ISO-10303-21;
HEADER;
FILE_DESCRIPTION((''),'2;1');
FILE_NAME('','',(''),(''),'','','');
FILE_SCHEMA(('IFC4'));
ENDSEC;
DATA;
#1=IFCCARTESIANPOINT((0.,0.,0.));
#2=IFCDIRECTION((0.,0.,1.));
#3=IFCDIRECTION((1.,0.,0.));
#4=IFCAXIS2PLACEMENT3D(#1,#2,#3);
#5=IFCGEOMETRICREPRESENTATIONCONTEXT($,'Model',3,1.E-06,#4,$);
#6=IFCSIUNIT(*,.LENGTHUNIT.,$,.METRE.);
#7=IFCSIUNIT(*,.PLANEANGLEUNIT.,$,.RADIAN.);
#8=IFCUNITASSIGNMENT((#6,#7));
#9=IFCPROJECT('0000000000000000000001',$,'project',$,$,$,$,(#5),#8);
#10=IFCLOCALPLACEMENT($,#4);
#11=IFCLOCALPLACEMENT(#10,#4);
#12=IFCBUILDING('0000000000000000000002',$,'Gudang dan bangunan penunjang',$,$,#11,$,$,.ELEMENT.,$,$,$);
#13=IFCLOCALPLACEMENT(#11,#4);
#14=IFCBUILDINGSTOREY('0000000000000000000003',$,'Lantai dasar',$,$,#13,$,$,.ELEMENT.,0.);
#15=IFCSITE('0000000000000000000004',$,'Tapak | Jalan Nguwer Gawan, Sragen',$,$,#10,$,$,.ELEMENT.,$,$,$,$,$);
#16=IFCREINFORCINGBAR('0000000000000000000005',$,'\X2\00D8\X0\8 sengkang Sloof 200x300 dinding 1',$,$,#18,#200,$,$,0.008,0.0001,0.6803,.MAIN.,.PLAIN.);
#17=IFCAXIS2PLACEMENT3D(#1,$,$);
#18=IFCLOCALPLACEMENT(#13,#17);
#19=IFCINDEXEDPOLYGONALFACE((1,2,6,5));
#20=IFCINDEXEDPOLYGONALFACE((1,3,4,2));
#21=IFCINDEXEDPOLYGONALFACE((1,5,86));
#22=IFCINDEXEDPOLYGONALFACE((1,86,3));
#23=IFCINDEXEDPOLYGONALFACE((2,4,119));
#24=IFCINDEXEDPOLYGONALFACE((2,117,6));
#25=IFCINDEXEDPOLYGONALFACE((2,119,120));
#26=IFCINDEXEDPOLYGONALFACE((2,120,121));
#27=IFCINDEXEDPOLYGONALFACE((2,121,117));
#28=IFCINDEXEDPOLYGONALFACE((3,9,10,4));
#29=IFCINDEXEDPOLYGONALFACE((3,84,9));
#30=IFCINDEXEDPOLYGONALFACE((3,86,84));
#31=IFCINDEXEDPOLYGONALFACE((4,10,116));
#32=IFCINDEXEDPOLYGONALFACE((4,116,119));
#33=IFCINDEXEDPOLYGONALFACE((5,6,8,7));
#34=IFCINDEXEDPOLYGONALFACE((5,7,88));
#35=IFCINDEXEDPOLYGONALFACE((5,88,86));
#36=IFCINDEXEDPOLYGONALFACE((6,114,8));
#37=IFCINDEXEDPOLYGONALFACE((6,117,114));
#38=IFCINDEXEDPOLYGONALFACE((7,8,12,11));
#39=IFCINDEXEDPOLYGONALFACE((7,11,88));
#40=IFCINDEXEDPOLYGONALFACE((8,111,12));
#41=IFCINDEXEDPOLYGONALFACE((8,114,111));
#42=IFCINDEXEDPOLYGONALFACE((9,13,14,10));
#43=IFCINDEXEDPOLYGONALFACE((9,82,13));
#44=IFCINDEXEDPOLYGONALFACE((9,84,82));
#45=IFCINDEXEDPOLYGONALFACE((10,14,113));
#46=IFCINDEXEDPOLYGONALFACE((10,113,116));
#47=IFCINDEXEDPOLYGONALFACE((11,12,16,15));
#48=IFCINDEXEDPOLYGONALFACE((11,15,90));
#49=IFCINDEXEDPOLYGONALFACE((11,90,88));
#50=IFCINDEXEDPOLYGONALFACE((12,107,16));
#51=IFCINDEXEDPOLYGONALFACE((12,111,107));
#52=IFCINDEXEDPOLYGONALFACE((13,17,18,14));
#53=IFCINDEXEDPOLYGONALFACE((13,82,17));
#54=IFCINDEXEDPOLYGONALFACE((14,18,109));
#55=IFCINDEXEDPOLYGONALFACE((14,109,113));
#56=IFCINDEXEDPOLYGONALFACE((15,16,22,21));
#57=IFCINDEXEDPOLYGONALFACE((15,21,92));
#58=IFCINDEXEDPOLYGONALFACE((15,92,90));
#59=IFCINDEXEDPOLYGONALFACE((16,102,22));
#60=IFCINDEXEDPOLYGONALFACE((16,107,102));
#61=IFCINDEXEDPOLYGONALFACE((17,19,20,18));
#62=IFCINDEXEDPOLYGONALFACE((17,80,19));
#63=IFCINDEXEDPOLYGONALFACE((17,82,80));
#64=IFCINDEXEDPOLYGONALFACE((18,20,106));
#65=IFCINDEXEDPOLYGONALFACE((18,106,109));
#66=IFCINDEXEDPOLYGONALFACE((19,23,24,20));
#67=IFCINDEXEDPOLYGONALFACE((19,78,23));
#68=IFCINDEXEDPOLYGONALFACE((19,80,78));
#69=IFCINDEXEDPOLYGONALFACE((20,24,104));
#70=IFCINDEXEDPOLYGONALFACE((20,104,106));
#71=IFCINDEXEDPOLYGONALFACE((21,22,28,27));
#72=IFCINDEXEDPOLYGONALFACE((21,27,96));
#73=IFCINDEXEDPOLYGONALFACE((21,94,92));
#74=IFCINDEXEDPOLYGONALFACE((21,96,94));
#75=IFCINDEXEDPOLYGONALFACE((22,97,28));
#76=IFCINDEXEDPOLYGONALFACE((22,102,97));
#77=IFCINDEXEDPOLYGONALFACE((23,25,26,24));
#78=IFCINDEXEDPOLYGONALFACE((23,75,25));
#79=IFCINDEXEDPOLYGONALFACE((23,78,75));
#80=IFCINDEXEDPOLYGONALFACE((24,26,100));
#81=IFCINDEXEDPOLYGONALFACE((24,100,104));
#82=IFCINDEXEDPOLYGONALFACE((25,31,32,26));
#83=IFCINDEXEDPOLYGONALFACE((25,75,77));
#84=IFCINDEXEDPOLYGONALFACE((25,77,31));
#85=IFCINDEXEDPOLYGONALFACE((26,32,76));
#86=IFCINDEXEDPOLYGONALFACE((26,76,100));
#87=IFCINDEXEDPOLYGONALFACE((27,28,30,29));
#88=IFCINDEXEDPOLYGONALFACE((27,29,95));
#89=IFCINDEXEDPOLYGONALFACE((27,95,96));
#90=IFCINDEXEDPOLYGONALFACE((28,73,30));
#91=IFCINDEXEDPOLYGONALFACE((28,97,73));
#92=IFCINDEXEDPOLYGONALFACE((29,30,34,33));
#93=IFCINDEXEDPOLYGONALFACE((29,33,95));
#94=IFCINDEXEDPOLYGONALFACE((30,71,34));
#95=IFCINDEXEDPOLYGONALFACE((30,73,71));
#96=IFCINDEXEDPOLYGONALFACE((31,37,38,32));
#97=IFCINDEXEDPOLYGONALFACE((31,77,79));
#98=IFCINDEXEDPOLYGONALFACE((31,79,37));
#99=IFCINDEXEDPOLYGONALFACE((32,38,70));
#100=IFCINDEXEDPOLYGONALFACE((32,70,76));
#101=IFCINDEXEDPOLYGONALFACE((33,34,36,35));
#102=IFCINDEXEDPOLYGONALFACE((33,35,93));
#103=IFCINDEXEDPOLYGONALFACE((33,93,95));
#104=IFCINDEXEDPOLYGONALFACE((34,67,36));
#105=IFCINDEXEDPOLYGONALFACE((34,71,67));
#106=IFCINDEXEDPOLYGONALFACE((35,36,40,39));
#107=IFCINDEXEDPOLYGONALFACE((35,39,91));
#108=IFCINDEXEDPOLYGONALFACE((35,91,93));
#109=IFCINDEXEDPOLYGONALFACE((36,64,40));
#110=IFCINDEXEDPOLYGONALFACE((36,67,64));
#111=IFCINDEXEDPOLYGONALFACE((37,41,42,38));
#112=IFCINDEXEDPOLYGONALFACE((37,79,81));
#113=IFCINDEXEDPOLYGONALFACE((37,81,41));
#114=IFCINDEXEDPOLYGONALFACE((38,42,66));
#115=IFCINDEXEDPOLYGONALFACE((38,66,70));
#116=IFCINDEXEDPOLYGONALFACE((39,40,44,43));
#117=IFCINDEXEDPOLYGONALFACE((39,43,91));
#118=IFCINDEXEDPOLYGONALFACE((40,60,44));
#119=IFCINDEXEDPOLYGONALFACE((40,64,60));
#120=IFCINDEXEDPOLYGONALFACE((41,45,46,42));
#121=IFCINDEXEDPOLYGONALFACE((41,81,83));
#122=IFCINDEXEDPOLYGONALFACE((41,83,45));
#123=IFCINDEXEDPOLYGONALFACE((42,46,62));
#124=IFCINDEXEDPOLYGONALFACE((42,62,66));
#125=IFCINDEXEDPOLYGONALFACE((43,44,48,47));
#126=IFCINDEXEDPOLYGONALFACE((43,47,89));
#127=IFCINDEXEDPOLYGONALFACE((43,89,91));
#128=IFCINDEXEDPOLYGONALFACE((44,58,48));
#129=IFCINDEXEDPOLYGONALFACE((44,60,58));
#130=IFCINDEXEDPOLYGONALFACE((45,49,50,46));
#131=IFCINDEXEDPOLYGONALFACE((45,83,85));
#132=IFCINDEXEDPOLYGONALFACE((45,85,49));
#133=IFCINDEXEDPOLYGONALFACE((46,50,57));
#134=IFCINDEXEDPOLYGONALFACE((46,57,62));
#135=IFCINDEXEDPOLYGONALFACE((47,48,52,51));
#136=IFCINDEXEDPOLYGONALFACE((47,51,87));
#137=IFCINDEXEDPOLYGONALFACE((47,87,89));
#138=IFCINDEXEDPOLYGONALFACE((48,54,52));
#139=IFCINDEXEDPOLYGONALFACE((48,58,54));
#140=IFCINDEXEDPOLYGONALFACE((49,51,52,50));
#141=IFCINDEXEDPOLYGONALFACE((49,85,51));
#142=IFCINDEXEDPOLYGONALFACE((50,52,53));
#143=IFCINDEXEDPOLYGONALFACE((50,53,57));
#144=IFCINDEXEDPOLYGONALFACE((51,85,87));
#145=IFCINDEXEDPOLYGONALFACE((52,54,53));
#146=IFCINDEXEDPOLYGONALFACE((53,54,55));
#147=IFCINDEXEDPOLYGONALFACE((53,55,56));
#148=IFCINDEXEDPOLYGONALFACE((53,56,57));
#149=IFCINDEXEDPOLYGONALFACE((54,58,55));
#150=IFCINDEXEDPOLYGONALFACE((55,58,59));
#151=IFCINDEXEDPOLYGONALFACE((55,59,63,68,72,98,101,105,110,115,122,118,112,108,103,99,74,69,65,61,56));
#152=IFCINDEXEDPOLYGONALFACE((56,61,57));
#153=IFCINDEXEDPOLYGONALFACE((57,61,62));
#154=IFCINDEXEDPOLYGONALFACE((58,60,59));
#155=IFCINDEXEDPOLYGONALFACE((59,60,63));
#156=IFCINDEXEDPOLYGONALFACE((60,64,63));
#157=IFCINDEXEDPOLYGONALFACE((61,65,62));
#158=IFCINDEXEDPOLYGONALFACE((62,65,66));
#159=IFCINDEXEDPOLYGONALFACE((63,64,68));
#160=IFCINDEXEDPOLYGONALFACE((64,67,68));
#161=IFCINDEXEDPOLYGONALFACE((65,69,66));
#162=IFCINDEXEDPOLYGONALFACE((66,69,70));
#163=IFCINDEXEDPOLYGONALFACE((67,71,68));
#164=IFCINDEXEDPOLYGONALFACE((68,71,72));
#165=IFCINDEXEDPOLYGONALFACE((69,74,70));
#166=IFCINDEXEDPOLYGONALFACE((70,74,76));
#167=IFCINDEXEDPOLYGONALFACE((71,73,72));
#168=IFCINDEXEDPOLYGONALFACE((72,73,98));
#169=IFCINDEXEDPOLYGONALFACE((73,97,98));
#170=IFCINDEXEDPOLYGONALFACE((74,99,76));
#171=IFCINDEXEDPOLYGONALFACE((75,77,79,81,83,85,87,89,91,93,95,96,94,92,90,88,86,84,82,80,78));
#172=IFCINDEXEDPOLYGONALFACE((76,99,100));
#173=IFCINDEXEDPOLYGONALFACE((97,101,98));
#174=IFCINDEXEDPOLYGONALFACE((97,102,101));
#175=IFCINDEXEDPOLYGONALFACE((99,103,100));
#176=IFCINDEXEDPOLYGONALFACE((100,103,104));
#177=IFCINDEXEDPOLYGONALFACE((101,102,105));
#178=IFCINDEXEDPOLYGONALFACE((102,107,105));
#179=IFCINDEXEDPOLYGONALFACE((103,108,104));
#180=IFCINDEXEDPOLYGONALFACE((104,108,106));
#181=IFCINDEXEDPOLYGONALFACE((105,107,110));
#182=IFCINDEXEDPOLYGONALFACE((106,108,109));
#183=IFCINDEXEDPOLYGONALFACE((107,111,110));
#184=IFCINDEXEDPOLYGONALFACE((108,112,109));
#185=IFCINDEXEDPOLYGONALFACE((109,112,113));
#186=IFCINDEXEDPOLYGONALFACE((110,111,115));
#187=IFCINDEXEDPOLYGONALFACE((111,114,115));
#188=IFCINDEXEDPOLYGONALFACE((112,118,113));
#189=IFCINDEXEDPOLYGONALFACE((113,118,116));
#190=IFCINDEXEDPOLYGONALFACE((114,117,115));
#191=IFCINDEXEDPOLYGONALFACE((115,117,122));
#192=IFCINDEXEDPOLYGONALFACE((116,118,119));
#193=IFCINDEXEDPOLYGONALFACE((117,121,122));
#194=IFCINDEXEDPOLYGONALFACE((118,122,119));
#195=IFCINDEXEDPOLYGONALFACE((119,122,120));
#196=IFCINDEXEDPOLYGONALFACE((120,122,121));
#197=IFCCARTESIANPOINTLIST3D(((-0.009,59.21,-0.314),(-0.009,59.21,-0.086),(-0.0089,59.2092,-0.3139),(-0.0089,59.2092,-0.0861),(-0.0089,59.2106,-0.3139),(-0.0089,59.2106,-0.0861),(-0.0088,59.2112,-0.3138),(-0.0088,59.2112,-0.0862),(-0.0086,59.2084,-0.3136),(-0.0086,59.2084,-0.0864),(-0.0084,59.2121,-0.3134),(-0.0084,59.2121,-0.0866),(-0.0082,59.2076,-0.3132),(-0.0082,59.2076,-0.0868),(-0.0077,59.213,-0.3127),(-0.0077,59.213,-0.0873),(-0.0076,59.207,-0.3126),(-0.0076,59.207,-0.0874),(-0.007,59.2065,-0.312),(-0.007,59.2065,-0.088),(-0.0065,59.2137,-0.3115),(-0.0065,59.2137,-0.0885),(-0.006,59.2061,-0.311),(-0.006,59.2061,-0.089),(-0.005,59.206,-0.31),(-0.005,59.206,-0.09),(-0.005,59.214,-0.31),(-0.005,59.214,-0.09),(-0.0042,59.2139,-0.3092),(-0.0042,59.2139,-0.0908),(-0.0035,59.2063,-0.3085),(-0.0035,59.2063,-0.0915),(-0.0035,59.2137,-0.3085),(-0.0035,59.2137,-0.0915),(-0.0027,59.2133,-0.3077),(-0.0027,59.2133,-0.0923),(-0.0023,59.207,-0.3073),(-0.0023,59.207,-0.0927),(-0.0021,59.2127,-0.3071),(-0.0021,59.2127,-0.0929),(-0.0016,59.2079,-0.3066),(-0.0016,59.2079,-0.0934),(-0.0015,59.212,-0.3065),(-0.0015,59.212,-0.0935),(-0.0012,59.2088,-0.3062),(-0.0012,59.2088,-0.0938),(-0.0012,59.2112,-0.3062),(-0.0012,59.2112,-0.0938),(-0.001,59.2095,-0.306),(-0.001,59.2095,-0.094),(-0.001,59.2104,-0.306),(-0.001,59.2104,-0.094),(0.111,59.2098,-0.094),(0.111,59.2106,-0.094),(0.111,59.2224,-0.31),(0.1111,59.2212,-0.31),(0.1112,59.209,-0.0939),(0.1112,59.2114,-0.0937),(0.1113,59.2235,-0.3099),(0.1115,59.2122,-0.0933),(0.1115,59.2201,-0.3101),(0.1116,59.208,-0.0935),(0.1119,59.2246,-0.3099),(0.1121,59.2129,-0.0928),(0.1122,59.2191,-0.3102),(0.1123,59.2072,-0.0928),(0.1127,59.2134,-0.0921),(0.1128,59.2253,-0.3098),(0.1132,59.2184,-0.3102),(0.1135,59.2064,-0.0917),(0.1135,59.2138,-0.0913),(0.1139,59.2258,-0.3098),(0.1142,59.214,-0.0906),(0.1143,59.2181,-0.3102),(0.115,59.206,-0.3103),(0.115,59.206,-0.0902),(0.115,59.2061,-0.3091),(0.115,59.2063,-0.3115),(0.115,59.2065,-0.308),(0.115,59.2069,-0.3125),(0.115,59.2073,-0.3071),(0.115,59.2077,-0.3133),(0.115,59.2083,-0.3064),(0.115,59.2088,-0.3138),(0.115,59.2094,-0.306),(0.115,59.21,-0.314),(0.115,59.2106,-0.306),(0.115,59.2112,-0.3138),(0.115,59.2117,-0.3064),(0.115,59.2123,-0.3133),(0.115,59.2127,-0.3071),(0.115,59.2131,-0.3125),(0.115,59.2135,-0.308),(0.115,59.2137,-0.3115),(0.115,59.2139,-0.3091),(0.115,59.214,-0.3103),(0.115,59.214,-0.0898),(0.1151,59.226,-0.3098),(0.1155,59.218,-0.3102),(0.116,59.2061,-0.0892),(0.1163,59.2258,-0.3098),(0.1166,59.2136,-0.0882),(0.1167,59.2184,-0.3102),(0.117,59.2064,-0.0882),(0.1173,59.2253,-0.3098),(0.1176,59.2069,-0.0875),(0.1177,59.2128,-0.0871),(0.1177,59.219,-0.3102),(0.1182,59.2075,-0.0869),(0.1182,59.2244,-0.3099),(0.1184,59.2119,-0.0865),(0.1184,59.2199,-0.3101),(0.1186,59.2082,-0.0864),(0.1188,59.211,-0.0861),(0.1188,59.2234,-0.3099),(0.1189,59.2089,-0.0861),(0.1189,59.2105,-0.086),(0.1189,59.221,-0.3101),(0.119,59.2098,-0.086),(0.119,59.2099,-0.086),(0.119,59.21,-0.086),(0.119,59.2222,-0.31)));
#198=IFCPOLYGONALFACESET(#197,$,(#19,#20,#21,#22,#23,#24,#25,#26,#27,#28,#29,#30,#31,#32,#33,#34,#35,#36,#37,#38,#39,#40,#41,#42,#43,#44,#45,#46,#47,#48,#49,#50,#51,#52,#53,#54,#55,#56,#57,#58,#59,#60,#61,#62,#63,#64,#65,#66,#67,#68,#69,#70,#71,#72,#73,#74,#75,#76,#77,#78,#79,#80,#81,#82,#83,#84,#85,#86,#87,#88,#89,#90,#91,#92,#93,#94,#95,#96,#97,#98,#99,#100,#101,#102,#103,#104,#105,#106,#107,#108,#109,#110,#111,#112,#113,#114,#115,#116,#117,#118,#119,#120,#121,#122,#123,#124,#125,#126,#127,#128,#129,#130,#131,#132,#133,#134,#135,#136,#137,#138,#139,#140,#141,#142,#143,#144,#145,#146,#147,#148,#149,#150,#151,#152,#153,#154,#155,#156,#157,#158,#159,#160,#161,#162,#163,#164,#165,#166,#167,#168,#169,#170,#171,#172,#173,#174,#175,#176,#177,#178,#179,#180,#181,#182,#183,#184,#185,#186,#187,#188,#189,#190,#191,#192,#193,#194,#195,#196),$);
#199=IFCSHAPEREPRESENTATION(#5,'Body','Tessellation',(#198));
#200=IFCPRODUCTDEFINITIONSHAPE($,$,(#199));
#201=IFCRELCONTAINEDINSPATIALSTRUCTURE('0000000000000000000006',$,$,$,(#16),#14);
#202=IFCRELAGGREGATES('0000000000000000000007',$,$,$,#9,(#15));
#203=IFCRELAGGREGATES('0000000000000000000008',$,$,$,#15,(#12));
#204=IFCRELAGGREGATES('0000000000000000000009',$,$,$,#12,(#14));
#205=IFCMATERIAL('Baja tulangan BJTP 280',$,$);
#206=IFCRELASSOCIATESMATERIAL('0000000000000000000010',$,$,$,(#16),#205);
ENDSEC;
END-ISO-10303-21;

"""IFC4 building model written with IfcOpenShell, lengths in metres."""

from ifc_helpers import new_model, entity, si_unit, origin_with_axes, place, context, project, spatial, material, element, save


model = new_model("IFC4")

# Units and contexts
model_context = context("Model", 3, precision=1e-06, world=origin_with_axes())
ifc_project = project(units=[si_unit("LENGTHUNIT", "METRE"), si_unit("PLANEANGLEUNIT", "RADIAN")], contexts=[model_context])

# Site, building, storey
site_placement = place(None, origin_with_axes())
site = spatial("IfcSite", under=ifc_project, at=site_placement, Name="Tapak | Jalan Nguwer Gawan, Sragen", CompositionType="ELEMENT")
building_placement = place(site_placement, origin_with_axes())
building = spatial("IfcBuilding", under=site, at=building_placement, Name="Gudang dan bangunan penunjang", CompositionType="ELEMENT")
storey_placement = place(building_placement, origin_with_axes())
storey = spatial("IfcBuildingStorey", under=building, at=storey_placement, Name="Lantai dasar", CompositionType="ELEMENT", Elevation=0.0)

# Shared definitions
placement = place(None, origin_with_axes())

# Reinforcing bar
ifc_material_1 = material(Name="Baja tulangan BJTP 280")
element("IfcReinforcingBar", 1, at=placement, inside=storey, material=ifc_material_1, Name="Ø8 sengkang Sloof 200x300 dinding 1", BarLength=0.6803, BarSurface="PLAIN", CrossSectionArea=0.0001, NominalDiameter=0.008, PredefinedType="MAIN", context=model_context, shape_type="AdvancedSweptSolid", body=[
    entity("IfcSweptDiskSolid", entity("IfcPolyline", [entity("IfcCartesianPoint", [0.115, 59.21, -0.31]), entity("IfcCartesianPoint", [-0.005, 59.21, -0.31]), entity("IfcCartesianPoint", [-0.005, 59.21, -0.09]), entity("IfcCartesianPoint", [0.115, 59.21, -0.09]), entity("IfcCartesianPoint", [0.115, 59.222, -0.31])]), 0.004),
])

save(model, "model.ifc")
